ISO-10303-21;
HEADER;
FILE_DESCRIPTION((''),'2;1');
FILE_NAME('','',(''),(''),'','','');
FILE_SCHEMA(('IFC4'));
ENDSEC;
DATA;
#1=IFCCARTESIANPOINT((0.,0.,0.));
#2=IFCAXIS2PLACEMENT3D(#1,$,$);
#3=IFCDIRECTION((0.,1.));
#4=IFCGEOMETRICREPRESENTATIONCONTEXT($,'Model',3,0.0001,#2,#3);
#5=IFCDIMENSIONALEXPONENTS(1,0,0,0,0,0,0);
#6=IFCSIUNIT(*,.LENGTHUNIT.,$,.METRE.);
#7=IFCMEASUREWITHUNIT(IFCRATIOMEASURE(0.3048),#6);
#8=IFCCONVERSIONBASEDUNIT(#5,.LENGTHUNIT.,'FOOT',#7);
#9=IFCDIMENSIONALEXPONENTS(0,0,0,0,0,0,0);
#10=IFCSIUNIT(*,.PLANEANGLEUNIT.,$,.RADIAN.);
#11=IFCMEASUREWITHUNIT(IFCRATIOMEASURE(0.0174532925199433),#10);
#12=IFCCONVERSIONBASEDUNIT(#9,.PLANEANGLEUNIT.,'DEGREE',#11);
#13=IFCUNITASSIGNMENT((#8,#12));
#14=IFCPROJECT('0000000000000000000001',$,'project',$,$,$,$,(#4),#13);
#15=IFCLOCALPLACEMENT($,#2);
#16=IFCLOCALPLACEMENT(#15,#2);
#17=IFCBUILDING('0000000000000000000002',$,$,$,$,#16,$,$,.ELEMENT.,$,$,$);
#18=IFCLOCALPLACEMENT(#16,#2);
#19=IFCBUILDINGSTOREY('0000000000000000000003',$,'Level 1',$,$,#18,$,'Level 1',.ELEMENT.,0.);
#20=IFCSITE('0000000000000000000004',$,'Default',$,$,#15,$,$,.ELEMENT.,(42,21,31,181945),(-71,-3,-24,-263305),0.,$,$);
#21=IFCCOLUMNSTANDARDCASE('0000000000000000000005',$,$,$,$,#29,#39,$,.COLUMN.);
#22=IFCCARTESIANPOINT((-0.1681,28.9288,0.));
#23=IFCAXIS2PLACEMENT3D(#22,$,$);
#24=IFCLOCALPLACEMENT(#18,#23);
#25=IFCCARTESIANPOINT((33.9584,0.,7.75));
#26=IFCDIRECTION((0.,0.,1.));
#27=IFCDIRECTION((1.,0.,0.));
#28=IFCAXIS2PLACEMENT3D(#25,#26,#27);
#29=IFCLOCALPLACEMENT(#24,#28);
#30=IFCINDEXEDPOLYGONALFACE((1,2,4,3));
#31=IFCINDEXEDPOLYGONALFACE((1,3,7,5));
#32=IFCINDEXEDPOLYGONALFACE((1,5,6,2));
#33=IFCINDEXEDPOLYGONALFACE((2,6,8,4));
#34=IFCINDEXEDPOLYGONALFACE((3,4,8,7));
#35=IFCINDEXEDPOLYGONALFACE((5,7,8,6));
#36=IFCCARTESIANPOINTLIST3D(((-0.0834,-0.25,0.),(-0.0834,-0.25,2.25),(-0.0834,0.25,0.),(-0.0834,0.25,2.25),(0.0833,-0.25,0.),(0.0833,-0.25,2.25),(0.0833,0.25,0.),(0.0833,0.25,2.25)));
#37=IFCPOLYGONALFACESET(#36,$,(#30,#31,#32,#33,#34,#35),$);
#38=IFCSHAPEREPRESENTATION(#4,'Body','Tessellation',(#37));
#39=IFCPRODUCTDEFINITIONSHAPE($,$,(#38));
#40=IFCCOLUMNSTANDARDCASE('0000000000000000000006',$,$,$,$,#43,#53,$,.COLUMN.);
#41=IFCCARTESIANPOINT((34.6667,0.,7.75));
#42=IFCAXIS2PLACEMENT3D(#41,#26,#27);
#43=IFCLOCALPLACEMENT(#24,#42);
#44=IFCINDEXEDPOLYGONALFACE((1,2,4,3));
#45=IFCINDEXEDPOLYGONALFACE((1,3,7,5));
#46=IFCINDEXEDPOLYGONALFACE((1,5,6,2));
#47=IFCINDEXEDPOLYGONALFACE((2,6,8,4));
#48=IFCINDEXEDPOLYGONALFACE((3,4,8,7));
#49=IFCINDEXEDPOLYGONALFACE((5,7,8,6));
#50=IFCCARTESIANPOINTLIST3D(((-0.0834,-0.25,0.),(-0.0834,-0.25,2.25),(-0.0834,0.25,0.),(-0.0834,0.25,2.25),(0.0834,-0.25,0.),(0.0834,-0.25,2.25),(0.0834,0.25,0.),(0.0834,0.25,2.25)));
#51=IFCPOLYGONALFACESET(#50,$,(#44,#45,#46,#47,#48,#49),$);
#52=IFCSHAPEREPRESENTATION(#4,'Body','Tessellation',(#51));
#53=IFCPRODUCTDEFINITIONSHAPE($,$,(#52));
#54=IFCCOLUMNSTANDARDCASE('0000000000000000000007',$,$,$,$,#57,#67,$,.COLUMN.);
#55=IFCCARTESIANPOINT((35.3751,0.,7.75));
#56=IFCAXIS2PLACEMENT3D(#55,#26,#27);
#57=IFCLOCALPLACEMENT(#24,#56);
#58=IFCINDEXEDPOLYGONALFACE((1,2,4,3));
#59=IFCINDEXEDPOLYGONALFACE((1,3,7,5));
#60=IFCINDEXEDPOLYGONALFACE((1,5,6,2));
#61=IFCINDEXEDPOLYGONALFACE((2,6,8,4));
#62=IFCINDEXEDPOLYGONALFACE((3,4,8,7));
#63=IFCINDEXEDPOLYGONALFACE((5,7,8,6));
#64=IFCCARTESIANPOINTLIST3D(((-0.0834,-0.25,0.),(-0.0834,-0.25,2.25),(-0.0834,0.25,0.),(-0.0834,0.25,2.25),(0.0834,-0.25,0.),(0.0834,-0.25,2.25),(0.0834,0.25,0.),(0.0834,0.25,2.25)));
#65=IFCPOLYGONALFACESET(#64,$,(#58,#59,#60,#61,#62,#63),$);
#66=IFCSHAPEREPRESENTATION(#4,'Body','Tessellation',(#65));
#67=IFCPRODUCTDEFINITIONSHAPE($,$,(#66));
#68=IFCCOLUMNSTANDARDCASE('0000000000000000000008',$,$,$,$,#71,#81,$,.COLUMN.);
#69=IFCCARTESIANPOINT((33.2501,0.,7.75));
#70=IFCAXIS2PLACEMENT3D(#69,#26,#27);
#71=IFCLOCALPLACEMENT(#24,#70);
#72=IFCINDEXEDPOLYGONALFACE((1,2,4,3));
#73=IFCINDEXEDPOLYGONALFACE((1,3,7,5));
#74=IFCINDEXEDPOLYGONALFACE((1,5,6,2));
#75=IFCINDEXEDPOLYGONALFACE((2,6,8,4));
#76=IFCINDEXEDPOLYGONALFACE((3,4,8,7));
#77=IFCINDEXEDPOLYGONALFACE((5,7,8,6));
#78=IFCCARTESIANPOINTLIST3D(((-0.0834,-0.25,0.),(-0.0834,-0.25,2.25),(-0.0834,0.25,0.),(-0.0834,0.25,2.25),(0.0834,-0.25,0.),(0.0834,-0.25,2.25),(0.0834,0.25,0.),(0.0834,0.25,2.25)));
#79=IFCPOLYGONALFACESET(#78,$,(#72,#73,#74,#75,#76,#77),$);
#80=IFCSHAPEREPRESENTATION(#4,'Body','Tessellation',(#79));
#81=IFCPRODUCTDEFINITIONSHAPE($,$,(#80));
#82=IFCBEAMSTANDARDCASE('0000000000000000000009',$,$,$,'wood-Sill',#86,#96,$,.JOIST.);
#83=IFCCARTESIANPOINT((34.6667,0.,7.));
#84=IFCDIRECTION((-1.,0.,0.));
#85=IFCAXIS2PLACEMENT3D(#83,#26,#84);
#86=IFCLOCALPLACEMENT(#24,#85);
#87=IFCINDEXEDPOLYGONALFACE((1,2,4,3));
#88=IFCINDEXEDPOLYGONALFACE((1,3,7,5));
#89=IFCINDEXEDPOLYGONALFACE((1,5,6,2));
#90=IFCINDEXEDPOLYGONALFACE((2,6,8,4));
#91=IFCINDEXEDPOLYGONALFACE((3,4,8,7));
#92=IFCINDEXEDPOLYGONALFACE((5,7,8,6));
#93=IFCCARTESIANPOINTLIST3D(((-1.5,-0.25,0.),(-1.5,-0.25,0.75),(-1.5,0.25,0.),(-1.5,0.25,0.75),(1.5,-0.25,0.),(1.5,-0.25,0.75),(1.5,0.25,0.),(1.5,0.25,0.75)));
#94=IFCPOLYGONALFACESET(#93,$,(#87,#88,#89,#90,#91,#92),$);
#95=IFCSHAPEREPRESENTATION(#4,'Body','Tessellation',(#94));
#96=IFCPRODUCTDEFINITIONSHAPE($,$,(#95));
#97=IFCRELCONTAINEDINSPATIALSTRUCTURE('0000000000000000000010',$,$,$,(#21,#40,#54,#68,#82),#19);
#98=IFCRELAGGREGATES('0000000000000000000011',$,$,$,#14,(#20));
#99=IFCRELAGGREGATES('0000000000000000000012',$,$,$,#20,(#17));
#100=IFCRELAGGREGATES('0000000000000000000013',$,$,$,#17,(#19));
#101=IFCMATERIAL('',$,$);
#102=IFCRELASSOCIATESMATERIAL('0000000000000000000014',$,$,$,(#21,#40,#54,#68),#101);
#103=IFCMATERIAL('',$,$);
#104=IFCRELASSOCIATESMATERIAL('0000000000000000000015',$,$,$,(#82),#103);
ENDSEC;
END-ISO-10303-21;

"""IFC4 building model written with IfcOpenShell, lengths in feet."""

from ifc_helpers import new_model, entity, si_unit, converted_unit, direction, frame, origin, place, context, project, spatial, rectangle, extrude, material, element, save


model = new_model("IFC4")

# Units and contexts
model_context = context("Model", 3, precision=0.0001, world=origin(), true_north=direction((0.0, 1.0)))
ifc_project = project(units=[converted_unit("LENGTHUNIT", "FOOT", entity("IfcRatioMeasure", 0.3048), si_unit("LENGTHUNIT", "METRE"), dimensions=[1, 0, 0, 0, 0, 0, 0]), converted_unit("PLANEANGLEUNIT", "DEGREE", entity("IfcRatioMeasure", 0.0174532925199433), si_unit("PLANEANGLEUNIT", "RADIAN"), dimensions=[0, 0, 0, 0, 0, 0, 0])], contexts=[model_context])

# Site, building, storey
site_placement = place(None, origin())
site = spatial("IfcSite", under=ifc_project, at=site_placement, Name="Default", CompositionType="ELEMENT", RefLatitude=(42, 21, 31, 181945), RefLongitude=(-71, -3, -24, -263305), RefElevation=0.0)
building_placement = place(site_placement, origin())
building = spatial("IfcBuilding", under=site, at=building_placement, CompositionType="ELEMENT")
storey_placement = place(building_placement, origin())
storey = spatial("IfcBuildingStorey", under=building, at=storey_placement, Name="Level 1", LongName="Level 1", CompositionType="ELEMENT", Elevation=0.0)

# Columns
ifc_material_1 = material(Name="")
placement = place(storey_placement, frame((-0.1681, 28.9288, 0.0)))
for number, where, z_axis, x_axis in (
    (1, (33.9584, 0.0, 7.75), (0.0, 0.0, 1.0), (1.0, 0.0, 0.0)),
    (2, (34.6667, 0.0, 7.75), (0.0, 0.0, 1.0), (1.0, 0.0, 0.0)),
    (3, (35.3751, 0.0, 7.75), (0.0, 0.0, 1.0), (1.0, 0.0, 0.0)),
    (4, (33.2501, 0.0, 7.75), (0.0, 0.0, 1.0), (1.0, 0.0, 0.0)),
):
    element("IfcColumnStandardCase", number, at=place(placement, frame(where, z_axis=z_axis, x_axis=x_axis)), inside=storey, material=ifc_material_1, PredefinedType="COLUMN", context=model_context, shape_type="SweptSolid", body=[
        extrude(rectangle(XDim=0.1667, YDim=0.5), origin(), (0.0, 0.0, 1.0), 2.25),
    ])

# Beam
ifc_material_2 = material(Name="")
for number, where, z_axis, x_axis in (
    (5, (34.6667, 0.0, 7.0), (0.0, 0.0, 1.0), (-1.0, 0.0, 0.0)),
):
    element("IfcBeamStandardCase", number, at=place(placement, frame(where, z_axis=z_axis, x_axis=x_axis)), inside=storey, material=ifc_material_2, ObjectType="wood-Sill", PredefinedType="JOIST", context=model_context, shape_type="SweptSolid", body=[
        extrude(rectangle(XDim=3.0, YDim=0.5), origin(), (0.0, 0.0, 1.0), 0.75),
    ])

save(model, "model.ifc")
